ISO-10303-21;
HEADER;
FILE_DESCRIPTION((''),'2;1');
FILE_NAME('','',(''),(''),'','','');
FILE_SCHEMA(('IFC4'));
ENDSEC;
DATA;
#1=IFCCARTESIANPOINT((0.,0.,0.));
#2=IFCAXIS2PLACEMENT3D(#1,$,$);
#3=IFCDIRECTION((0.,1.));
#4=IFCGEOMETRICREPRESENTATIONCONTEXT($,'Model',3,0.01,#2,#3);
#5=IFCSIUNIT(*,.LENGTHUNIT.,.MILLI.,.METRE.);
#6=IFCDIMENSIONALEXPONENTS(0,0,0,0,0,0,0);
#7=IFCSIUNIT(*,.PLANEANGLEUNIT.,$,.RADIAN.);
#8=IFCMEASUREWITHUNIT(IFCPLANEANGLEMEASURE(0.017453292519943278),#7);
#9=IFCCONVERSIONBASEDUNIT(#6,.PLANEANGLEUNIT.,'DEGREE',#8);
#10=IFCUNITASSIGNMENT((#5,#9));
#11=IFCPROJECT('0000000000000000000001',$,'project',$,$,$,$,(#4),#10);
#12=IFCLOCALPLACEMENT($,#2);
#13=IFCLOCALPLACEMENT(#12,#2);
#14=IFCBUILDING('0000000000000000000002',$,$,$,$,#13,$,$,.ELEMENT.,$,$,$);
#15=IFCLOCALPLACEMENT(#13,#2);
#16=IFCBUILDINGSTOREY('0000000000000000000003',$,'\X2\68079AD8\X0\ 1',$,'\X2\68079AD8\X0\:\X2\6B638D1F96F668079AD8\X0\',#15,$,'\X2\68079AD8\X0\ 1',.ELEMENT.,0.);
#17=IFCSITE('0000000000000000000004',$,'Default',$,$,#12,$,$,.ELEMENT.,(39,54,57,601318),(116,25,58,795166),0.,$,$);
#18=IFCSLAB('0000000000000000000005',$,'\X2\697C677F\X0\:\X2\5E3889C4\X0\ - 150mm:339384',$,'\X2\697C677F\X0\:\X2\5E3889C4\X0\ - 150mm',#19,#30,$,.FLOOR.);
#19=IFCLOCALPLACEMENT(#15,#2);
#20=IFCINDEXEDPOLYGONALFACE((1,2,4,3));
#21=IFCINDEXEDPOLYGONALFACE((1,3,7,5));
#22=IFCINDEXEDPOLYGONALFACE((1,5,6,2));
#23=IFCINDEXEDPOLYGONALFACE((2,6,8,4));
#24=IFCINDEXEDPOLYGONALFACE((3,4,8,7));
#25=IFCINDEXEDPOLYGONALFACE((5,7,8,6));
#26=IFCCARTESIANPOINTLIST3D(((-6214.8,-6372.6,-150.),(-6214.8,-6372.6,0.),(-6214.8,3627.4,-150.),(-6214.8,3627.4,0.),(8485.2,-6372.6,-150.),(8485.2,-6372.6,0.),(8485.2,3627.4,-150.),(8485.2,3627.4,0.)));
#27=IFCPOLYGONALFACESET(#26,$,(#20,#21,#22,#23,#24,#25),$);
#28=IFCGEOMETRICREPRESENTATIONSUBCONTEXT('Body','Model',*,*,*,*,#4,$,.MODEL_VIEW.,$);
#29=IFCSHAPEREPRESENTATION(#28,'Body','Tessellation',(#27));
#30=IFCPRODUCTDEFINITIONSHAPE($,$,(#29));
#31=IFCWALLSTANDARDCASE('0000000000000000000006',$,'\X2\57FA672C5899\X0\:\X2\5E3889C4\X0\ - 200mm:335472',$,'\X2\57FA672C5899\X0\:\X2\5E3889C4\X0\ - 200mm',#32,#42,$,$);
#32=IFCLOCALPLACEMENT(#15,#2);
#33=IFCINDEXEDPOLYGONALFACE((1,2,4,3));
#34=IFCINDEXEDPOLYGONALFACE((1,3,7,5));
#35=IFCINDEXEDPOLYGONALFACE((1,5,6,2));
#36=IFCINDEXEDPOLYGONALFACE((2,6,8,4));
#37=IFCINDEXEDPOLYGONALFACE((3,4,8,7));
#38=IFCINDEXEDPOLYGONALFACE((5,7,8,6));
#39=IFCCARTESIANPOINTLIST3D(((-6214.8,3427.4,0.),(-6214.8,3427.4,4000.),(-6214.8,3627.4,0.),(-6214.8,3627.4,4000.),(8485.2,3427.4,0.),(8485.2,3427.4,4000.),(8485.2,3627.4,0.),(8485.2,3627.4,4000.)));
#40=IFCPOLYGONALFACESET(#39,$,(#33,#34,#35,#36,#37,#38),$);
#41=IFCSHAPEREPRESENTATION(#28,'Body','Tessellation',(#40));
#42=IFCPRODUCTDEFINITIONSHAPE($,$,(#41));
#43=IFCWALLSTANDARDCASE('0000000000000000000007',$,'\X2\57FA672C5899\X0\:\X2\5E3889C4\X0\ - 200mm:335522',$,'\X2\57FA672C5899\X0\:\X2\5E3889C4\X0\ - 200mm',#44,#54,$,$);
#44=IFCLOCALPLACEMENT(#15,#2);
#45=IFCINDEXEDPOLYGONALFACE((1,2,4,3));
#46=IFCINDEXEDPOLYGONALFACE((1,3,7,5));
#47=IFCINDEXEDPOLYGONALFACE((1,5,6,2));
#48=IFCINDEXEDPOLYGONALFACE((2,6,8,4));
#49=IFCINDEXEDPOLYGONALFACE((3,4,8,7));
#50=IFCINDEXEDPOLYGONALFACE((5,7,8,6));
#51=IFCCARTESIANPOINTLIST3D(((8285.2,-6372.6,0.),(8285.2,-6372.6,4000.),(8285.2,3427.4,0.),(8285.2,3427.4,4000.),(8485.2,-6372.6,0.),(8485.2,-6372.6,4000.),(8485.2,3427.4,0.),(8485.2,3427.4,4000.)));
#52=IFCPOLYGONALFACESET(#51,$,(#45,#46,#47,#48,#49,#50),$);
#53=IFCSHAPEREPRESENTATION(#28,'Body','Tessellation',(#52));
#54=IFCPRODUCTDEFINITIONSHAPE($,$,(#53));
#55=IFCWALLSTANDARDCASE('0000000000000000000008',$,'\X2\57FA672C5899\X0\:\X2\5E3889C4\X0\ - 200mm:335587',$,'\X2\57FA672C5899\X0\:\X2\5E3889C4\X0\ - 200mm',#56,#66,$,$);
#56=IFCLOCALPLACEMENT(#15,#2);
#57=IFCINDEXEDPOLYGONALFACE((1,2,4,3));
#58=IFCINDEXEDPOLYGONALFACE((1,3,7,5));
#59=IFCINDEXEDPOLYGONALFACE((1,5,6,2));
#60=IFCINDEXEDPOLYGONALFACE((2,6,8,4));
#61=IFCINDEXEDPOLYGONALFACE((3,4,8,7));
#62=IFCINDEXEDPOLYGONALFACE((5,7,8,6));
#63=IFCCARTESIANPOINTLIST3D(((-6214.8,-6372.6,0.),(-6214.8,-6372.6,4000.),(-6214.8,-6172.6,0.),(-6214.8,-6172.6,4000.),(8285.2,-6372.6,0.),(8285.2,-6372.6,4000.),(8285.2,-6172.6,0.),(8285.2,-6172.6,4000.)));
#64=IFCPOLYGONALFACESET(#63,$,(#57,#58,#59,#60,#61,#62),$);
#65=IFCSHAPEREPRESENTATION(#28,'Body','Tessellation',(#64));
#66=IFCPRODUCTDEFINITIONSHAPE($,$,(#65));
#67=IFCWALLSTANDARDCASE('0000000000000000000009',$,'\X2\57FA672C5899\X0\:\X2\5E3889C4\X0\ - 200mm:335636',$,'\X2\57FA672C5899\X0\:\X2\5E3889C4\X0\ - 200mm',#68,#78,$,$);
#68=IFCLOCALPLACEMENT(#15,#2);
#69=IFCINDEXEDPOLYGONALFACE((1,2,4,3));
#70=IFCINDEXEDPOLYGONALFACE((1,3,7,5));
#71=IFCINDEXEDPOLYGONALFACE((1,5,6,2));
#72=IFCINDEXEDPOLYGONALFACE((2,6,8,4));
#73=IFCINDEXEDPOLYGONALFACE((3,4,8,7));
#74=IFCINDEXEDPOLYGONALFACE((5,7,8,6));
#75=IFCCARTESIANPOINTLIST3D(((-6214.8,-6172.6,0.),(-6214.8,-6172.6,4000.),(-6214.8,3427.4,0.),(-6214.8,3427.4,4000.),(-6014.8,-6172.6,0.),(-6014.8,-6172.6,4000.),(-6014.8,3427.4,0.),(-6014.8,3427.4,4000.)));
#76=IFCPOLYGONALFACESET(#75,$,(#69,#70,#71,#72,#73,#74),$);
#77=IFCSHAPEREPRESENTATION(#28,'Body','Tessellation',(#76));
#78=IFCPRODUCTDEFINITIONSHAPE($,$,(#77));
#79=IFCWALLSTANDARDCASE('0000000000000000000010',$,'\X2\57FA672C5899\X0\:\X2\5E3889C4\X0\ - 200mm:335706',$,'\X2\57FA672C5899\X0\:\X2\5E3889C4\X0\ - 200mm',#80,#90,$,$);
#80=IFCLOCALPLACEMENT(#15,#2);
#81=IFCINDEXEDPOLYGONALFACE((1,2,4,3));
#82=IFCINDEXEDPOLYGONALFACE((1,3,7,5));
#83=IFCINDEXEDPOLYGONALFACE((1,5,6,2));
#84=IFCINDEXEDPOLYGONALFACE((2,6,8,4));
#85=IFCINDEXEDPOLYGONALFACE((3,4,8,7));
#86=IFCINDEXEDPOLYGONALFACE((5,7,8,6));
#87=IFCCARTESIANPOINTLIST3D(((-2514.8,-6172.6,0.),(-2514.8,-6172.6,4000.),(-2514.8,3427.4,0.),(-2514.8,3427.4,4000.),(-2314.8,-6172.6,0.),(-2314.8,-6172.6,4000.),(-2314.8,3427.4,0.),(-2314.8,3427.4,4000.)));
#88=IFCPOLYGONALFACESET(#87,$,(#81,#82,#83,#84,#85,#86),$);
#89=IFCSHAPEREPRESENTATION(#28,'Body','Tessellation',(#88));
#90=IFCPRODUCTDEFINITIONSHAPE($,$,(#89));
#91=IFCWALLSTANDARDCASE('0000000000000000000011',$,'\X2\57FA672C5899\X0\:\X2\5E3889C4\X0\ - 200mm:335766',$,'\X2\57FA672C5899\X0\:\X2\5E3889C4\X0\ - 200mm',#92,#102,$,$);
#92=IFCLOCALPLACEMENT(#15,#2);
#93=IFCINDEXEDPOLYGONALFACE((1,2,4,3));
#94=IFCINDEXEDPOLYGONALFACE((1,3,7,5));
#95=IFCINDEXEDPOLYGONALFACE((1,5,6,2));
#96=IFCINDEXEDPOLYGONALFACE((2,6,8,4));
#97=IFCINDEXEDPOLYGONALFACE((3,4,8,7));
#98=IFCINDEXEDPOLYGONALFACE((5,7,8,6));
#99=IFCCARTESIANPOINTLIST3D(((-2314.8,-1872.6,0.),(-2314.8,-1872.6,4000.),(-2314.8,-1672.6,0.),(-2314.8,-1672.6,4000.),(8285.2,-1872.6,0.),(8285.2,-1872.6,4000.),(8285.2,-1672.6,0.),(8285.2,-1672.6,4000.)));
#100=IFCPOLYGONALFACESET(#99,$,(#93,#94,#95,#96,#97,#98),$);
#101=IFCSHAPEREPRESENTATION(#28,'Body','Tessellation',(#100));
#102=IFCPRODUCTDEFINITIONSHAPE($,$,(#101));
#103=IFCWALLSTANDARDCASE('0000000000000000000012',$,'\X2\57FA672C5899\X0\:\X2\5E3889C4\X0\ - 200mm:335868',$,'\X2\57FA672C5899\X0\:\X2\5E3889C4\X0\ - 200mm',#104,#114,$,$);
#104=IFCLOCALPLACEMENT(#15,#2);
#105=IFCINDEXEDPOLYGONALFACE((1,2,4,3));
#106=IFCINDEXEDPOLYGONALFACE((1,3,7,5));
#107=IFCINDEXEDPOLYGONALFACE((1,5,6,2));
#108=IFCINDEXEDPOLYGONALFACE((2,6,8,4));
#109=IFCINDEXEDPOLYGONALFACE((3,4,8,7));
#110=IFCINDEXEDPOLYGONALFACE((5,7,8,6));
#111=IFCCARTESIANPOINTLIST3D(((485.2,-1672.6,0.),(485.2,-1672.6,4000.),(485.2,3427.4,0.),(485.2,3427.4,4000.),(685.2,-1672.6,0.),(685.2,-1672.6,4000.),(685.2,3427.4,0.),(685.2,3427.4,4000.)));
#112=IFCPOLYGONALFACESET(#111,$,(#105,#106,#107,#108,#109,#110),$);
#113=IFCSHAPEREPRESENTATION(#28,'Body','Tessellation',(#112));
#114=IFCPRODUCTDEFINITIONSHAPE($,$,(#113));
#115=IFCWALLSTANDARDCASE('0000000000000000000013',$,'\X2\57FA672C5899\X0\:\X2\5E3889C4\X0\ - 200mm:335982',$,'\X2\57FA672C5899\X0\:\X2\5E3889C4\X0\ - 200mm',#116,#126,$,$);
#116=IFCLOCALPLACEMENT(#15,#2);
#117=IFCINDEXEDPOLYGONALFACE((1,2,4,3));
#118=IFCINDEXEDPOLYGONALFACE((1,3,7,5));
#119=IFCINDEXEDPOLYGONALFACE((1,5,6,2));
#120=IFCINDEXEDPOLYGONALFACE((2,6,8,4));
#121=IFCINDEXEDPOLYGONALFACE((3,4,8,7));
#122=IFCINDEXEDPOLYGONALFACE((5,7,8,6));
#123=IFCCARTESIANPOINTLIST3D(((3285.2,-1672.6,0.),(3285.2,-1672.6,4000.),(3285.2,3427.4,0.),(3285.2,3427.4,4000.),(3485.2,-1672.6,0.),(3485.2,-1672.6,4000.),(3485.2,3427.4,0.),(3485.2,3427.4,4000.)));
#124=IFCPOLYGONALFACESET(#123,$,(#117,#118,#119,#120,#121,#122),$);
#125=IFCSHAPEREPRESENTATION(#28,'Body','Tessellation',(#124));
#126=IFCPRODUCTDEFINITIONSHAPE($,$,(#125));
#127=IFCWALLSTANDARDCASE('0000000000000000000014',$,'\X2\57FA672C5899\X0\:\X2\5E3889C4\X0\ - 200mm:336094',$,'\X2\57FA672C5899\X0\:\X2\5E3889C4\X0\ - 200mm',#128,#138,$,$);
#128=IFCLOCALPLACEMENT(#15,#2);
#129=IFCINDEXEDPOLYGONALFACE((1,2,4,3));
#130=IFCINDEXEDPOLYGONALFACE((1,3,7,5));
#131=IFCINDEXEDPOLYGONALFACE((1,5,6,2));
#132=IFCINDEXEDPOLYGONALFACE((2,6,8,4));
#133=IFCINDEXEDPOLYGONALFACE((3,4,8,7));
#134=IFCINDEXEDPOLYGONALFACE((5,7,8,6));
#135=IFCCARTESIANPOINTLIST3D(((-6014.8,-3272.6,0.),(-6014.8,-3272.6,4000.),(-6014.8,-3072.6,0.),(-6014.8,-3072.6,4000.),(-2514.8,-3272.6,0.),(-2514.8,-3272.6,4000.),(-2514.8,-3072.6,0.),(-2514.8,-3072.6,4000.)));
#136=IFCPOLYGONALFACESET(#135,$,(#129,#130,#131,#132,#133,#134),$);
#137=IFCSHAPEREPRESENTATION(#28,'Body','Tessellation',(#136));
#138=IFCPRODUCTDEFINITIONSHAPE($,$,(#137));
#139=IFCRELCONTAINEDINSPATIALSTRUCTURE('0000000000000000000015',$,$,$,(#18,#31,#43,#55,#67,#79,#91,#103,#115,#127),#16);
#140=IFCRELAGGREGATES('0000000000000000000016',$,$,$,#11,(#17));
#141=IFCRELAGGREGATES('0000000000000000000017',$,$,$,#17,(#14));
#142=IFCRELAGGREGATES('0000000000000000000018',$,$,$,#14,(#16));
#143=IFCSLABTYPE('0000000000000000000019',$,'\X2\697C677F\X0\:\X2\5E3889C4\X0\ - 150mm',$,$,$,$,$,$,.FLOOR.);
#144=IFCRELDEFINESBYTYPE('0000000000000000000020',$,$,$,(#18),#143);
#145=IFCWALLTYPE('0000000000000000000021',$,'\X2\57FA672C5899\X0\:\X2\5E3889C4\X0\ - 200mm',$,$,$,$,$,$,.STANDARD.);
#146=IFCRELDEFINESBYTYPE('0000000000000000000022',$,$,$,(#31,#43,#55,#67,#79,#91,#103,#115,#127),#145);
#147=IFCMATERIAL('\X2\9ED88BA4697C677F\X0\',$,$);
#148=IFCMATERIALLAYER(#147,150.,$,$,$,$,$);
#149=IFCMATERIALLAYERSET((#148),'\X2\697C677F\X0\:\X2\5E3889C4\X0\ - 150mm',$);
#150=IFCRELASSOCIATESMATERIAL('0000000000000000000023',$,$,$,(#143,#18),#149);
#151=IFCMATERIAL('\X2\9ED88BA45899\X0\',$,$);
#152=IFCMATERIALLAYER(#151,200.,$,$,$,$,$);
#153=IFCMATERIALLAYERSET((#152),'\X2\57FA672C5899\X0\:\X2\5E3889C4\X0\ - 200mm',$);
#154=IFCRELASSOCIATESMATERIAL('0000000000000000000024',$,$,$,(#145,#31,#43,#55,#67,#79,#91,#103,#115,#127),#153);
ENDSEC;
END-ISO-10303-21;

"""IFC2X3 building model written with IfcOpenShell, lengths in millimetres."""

from ifc_helpers import new_model, entity, si_unit, converted_unit, direction, frame, frame_2d, origin, origin_2d_with_axis, place, context, subcontext, project, spatial, rectangle, extrude, material, layer, layer_set, layer_usage, type_object, element, save


model = new_model("IFC2X3")

# Units and contexts
model_context = context("Model", 3, precision=0.01, world=origin(), true_north=direction((0.0, 1.0)))
body_context = subcontext(model_context, "Body", "Model", "MODEL_VIEW")
ifc_project = project(units=[si_unit("LENGTHUNIT", "METRE", prefix="MILLI"), converted_unit("PLANEANGLEUNIT", "DEGREE", entity("IfcPlaneAngleMeasure", 0.017453292519943278), si_unit("PLANEANGLEUNIT", "RADIAN"), dimensions=[0, 0, 0, 0, 0, 0, 0])], contexts=[model_context])

# Site, building, storey
site_placement = place(None, origin())
site = spatial("IfcSite", under=ifc_project, at=site_placement, Name="Default", CompositionType="ELEMENT", RefLatitude=(39, 54, 57, 601318), RefLongitude=(116, 25, 58, 795166), RefElevation=0.0)
building_placement = place(site_placement, origin())
building = spatial("IfcBuilding", under=site, at=building_placement, CompositionType="ELEMENT")
storey_placement = place(building_placement, origin())
storey = spatial("IfcBuildingStorey", under=building, at=storey_placement, Name="标高 1", ObjectType="标高:正负零标高", LongName="标高 1", CompositionType="ELEMENT", Elevation=0.0)

# Slab
ifc_material_1 = material(Name="默认楼板")
ifc_layer_1 = layer(ifc_material_1, 150.0)
ifc_layer_set_1 = layer_set([ifc_layer_1], Name="楼板:常规 - 150mm")
ifc_layer_usage_1 = layer_usage(ifc_layer_set_1, "AXIS3", "POSITIVE", 0.0)
slab_type = type_object("IfcSlabType", Name="楼板:常规 - 150mm", PredefinedType="FLOOR", material=ifc_layer_set_1)
slab_placement = place(storey_placement, origin())
element("IfcSlab", 1, at=slab_placement, inside=storey, type_object=slab_type, material=ifc_layer_usage_1, Name="楼板:常规 - 150mm:339384", ObjectType="楼板:常规 - 150mm", PredefinedType="FLOOR", context=body_context, shape_type="SweptSolid", body=[
    extrude(rectangle(XDim=10000.0, YDim=14700.0, at=origin_2d_with_axis()), frame((1135.2, -1372.6, 0.0), z_axis=(0.0, 0.0, -1.0), x_axis=(0.0, 1.0, 0.0)), (0.0, 0.0, 1.0), 150.0),
])

# Walls
ifc_material_2 = material(Name="默认墙")
ifc_layer_2 = layer(ifc_material_2, 200.0)
ifc_layer_set_2 = layer_set([ifc_layer_2], Name="基本墙:常规 - 200mm")
ifc_layer_usage_2 = layer_usage(ifc_layer_set_2, "AXIS2", "NEGATIVE", 100.0)
wall_type = type_object("IfcWallType", Name="基本墙:常规 - 200mm", PredefinedType="STANDARD", material=ifc_layer_set_2)
wall_1_placement = place(storey_placement, frame((-6214.8, 3527.4, 0.0)))
element("IfcWallStandardCase", 2, at=wall_1_placement, inside=storey, type_object=wall_type, material=ifc_layer_usage_2, Name="基本墙:常规 - 200mm:335472", ObjectType="基本墙:常规 - 200mm", context=body_context, shape_type="SweptSolid", body=[
    extrude(rectangle(XDim=14700.0, YDim=200.0, at=frame_2d((7350.0, 0.0), x_axis=(-1.0, 0.0))), origin(), (0.0, 0.0, 1.0), 4000.0),
])
ifc_layer_usage_3 = layer_usage(ifc_layer_set_2, "AXIS2", "NEGATIVE", 100.0)
wall_2_placement = place(storey_placement, frame((8385.2, 3427.4, 0.0), z_axis=(0.0, 0.0, 1.0), x_axis=(0.0, -1.0, 0.0)))
element("IfcWallStandardCase", 3, at=wall_2_placement, inside=storey, type_object=wall_type, material=ifc_layer_usage_3, Name="基本墙:常规 - 200mm:335522", ObjectType="基本墙:常规 - 200mm", context=body_context, shape_type="SweptSolid", body=[
    extrude(rectangle(XDim=9800.0, YDim=200.0, at=frame_2d((4900.0, 0.0), x_axis=(-1.0, 0.0))), origin(), (0.0, 0.0, 1.0), 4000.0),
])
ifc_layer_usage_4 = layer_usage(ifc_layer_set_2, "AXIS2", "NEGATIVE", 100.0)
wall_3_placement = place(storey_placement, frame((8285.2, -6272.6, 0.0), z_axis=(0.0, 0.0, 1.0), x_axis=(-1.0, 0.0, 0.0)))
element("IfcWallStandardCase", 4, at=wall_3_placement, inside=storey, type_object=wall_type, material=ifc_layer_usage_4, Name="基本墙:常规 - 200mm:335587", ObjectType="基本墙:常规 - 200mm", context=body_context, shape_type="SweptSolid", body=[
    extrude(rectangle(XDim=14500.0, YDim=200.0, at=frame_2d((7250.0, 0.0), x_axis=(-1.0, 0.0))), origin(), (0.0, 0.0, 1.0), 4000.0),
])
ifc_layer_usage_5 = layer_usage(ifc_layer_set_2, "AXIS2", "NEGATIVE", 100.0)
wall_4_placement = place(storey_placement, frame((-6114.8, -6172.6, 0.0), z_axis=(0.0, 0.0, 1.0), x_axis=(0.0, 1.0, 0.0)))
element("IfcWallStandardCase", 5, at=wall_4_placement, inside=storey, type_object=wall_type, material=ifc_layer_usage_5, Name="基本墙:常规 - 200mm:335636", ObjectType="基本墙:常规 - 200mm", context=body_context, shape_type="SweptSolid", body=[
    extrude(rectangle(XDim=9600.0, YDim=200.0, at=frame_2d((4800.0, 0.0), x_axis=(-1.0, 0.0))), origin(), (0.0, 0.0, 1.0), 4000.0),
])
ifc_layer_usage_6 = layer_usage(ifc_layer_set_2, "AXIS2", "NEGATIVE", 100.0)
wall_5_placement = place(storey_placement, frame((-2414.8, 3427.4, 0.0), z_axis=(0.0, 0.0, 1.0), x_axis=(0.0, -1.0, 0.0)))
element("IfcWallStandardCase", 6, at=wall_5_placement, inside=storey, type_object=wall_type, material=ifc_layer_usage_6, Name="基本墙:常规 - 200mm:335706", ObjectType="基本墙:常规 - 200mm", context=body_context, shape_type="SweptSolid", body=[
    extrude(rectangle(XDim=9600.0, YDim=200.0, at=frame_2d((4800.0, 0.0), x_axis=(-1.0, 0.0))), origin(), (0.0, 0.0, 1.0), 4000.0),
])
ifc_layer_usage_7 = layer_usage(ifc_layer_set_2, "AXIS2", "NEGATIVE", 100.0)
wall_6_placement = place(storey_placement, frame((-2314.8, -1772.6, 0.0)))
element("IfcWallStandardCase", 7, at=wall_6_placement, inside=storey, type_object=wall_type, material=ifc_layer_usage_7, Name="基本墙:常规 - 200mm:335766", ObjectType="基本墙:常规 - 200mm", context=body_context, shape_type="SweptSolid", body=[
    extrude(rectangle(XDim=10600.0, YDim=200.0, at=frame_2d((5300.0, 0.0), x_axis=(-1.0, 0.0))), origin(), (0.0, 0.0, 1.0), 4000.0),
])
ifc_layer_usage_8 = layer_usage(ifc_layer_set_2, "AXIS2", "NEGATIVE", 100.0)
wall_7_placement = place(storey_placement, frame((585.2, 3427.4, 0.0), z_axis=(0.0, 0.0, 1.0), x_axis=(0.0, -1.0, 0.0)))
element("IfcWallStandardCase", 8, at=wall_7_placement, inside=storey, type_object=wall_type, material=ifc_layer_usage_8, Name="基本墙:常规 - 200mm:335868", ObjectType="基本墙:常规 - 200mm", context=body_context, shape_type="SweptSolid", body=[
    extrude(rectangle(XDim=5100.0, YDim=200.0, at=frame_2d((2550.0, 0.0), x_axis=(-1.0, 0.0))), origin(), (0.0, 0.0, 1.0), 4000.0),
])
ifc_layer_usage_9 = layer_usage(ifc_layer_set_2, "AXIS2", "NEGATIVE", 100.0)
wall_8_placement = place(storey_placement, frame((3385.2, 3427.4, 0.0), z_axis=(0.0, 0.0, 1.0), x_axis=(0.0, -1.0, 0.0)))
element("IfcWallStandardCase", 9, at=wall_8_placement, inside=storey, type_object=wall_type, material=ifc_layer_usage_9, Name="基本墙:常规 - 200mm:335982", ObjectType="基本墙:常规 - 200mm", context=body_context, shape_type="SweptSolid", body=[
    extrude(rectangle(XDim=5100.0, YDim=200.0, at=frame_2d((2550.0, 0.0), x_axis=(-1.0, 0.0))), origin(), (0.0, 0.0, 1.0), 4000.0),
])
ifc_layer_usage_10 = layer_usage(ifc_layer_set_2, "AXIS2", "NEGATIVE", 100.0)
wall_9_placement = place(storey_placement, frame((-6014.8, -3172.6, 0.0)))
element("IfcWallStandardCase", 10, at=wall_9_placement, inside=storey, type_object=wall_type, material=ifc_layer_usage_10, Name="基本墙:常规 - 200mm:336094", ObjectType="基本墙:常规 - 200mm", context=body_context, shape_type="SweptSolid", body=[
    extrude(rectangle(XDim=3500.0, YDim=200.0, at=frame_2d((1750.0, 0.0), x_axis=(-1.0, 0.0))), origin(), (0.0, 0.0, 1.0), 4000.0),
])

save(model, "model.ifc")
